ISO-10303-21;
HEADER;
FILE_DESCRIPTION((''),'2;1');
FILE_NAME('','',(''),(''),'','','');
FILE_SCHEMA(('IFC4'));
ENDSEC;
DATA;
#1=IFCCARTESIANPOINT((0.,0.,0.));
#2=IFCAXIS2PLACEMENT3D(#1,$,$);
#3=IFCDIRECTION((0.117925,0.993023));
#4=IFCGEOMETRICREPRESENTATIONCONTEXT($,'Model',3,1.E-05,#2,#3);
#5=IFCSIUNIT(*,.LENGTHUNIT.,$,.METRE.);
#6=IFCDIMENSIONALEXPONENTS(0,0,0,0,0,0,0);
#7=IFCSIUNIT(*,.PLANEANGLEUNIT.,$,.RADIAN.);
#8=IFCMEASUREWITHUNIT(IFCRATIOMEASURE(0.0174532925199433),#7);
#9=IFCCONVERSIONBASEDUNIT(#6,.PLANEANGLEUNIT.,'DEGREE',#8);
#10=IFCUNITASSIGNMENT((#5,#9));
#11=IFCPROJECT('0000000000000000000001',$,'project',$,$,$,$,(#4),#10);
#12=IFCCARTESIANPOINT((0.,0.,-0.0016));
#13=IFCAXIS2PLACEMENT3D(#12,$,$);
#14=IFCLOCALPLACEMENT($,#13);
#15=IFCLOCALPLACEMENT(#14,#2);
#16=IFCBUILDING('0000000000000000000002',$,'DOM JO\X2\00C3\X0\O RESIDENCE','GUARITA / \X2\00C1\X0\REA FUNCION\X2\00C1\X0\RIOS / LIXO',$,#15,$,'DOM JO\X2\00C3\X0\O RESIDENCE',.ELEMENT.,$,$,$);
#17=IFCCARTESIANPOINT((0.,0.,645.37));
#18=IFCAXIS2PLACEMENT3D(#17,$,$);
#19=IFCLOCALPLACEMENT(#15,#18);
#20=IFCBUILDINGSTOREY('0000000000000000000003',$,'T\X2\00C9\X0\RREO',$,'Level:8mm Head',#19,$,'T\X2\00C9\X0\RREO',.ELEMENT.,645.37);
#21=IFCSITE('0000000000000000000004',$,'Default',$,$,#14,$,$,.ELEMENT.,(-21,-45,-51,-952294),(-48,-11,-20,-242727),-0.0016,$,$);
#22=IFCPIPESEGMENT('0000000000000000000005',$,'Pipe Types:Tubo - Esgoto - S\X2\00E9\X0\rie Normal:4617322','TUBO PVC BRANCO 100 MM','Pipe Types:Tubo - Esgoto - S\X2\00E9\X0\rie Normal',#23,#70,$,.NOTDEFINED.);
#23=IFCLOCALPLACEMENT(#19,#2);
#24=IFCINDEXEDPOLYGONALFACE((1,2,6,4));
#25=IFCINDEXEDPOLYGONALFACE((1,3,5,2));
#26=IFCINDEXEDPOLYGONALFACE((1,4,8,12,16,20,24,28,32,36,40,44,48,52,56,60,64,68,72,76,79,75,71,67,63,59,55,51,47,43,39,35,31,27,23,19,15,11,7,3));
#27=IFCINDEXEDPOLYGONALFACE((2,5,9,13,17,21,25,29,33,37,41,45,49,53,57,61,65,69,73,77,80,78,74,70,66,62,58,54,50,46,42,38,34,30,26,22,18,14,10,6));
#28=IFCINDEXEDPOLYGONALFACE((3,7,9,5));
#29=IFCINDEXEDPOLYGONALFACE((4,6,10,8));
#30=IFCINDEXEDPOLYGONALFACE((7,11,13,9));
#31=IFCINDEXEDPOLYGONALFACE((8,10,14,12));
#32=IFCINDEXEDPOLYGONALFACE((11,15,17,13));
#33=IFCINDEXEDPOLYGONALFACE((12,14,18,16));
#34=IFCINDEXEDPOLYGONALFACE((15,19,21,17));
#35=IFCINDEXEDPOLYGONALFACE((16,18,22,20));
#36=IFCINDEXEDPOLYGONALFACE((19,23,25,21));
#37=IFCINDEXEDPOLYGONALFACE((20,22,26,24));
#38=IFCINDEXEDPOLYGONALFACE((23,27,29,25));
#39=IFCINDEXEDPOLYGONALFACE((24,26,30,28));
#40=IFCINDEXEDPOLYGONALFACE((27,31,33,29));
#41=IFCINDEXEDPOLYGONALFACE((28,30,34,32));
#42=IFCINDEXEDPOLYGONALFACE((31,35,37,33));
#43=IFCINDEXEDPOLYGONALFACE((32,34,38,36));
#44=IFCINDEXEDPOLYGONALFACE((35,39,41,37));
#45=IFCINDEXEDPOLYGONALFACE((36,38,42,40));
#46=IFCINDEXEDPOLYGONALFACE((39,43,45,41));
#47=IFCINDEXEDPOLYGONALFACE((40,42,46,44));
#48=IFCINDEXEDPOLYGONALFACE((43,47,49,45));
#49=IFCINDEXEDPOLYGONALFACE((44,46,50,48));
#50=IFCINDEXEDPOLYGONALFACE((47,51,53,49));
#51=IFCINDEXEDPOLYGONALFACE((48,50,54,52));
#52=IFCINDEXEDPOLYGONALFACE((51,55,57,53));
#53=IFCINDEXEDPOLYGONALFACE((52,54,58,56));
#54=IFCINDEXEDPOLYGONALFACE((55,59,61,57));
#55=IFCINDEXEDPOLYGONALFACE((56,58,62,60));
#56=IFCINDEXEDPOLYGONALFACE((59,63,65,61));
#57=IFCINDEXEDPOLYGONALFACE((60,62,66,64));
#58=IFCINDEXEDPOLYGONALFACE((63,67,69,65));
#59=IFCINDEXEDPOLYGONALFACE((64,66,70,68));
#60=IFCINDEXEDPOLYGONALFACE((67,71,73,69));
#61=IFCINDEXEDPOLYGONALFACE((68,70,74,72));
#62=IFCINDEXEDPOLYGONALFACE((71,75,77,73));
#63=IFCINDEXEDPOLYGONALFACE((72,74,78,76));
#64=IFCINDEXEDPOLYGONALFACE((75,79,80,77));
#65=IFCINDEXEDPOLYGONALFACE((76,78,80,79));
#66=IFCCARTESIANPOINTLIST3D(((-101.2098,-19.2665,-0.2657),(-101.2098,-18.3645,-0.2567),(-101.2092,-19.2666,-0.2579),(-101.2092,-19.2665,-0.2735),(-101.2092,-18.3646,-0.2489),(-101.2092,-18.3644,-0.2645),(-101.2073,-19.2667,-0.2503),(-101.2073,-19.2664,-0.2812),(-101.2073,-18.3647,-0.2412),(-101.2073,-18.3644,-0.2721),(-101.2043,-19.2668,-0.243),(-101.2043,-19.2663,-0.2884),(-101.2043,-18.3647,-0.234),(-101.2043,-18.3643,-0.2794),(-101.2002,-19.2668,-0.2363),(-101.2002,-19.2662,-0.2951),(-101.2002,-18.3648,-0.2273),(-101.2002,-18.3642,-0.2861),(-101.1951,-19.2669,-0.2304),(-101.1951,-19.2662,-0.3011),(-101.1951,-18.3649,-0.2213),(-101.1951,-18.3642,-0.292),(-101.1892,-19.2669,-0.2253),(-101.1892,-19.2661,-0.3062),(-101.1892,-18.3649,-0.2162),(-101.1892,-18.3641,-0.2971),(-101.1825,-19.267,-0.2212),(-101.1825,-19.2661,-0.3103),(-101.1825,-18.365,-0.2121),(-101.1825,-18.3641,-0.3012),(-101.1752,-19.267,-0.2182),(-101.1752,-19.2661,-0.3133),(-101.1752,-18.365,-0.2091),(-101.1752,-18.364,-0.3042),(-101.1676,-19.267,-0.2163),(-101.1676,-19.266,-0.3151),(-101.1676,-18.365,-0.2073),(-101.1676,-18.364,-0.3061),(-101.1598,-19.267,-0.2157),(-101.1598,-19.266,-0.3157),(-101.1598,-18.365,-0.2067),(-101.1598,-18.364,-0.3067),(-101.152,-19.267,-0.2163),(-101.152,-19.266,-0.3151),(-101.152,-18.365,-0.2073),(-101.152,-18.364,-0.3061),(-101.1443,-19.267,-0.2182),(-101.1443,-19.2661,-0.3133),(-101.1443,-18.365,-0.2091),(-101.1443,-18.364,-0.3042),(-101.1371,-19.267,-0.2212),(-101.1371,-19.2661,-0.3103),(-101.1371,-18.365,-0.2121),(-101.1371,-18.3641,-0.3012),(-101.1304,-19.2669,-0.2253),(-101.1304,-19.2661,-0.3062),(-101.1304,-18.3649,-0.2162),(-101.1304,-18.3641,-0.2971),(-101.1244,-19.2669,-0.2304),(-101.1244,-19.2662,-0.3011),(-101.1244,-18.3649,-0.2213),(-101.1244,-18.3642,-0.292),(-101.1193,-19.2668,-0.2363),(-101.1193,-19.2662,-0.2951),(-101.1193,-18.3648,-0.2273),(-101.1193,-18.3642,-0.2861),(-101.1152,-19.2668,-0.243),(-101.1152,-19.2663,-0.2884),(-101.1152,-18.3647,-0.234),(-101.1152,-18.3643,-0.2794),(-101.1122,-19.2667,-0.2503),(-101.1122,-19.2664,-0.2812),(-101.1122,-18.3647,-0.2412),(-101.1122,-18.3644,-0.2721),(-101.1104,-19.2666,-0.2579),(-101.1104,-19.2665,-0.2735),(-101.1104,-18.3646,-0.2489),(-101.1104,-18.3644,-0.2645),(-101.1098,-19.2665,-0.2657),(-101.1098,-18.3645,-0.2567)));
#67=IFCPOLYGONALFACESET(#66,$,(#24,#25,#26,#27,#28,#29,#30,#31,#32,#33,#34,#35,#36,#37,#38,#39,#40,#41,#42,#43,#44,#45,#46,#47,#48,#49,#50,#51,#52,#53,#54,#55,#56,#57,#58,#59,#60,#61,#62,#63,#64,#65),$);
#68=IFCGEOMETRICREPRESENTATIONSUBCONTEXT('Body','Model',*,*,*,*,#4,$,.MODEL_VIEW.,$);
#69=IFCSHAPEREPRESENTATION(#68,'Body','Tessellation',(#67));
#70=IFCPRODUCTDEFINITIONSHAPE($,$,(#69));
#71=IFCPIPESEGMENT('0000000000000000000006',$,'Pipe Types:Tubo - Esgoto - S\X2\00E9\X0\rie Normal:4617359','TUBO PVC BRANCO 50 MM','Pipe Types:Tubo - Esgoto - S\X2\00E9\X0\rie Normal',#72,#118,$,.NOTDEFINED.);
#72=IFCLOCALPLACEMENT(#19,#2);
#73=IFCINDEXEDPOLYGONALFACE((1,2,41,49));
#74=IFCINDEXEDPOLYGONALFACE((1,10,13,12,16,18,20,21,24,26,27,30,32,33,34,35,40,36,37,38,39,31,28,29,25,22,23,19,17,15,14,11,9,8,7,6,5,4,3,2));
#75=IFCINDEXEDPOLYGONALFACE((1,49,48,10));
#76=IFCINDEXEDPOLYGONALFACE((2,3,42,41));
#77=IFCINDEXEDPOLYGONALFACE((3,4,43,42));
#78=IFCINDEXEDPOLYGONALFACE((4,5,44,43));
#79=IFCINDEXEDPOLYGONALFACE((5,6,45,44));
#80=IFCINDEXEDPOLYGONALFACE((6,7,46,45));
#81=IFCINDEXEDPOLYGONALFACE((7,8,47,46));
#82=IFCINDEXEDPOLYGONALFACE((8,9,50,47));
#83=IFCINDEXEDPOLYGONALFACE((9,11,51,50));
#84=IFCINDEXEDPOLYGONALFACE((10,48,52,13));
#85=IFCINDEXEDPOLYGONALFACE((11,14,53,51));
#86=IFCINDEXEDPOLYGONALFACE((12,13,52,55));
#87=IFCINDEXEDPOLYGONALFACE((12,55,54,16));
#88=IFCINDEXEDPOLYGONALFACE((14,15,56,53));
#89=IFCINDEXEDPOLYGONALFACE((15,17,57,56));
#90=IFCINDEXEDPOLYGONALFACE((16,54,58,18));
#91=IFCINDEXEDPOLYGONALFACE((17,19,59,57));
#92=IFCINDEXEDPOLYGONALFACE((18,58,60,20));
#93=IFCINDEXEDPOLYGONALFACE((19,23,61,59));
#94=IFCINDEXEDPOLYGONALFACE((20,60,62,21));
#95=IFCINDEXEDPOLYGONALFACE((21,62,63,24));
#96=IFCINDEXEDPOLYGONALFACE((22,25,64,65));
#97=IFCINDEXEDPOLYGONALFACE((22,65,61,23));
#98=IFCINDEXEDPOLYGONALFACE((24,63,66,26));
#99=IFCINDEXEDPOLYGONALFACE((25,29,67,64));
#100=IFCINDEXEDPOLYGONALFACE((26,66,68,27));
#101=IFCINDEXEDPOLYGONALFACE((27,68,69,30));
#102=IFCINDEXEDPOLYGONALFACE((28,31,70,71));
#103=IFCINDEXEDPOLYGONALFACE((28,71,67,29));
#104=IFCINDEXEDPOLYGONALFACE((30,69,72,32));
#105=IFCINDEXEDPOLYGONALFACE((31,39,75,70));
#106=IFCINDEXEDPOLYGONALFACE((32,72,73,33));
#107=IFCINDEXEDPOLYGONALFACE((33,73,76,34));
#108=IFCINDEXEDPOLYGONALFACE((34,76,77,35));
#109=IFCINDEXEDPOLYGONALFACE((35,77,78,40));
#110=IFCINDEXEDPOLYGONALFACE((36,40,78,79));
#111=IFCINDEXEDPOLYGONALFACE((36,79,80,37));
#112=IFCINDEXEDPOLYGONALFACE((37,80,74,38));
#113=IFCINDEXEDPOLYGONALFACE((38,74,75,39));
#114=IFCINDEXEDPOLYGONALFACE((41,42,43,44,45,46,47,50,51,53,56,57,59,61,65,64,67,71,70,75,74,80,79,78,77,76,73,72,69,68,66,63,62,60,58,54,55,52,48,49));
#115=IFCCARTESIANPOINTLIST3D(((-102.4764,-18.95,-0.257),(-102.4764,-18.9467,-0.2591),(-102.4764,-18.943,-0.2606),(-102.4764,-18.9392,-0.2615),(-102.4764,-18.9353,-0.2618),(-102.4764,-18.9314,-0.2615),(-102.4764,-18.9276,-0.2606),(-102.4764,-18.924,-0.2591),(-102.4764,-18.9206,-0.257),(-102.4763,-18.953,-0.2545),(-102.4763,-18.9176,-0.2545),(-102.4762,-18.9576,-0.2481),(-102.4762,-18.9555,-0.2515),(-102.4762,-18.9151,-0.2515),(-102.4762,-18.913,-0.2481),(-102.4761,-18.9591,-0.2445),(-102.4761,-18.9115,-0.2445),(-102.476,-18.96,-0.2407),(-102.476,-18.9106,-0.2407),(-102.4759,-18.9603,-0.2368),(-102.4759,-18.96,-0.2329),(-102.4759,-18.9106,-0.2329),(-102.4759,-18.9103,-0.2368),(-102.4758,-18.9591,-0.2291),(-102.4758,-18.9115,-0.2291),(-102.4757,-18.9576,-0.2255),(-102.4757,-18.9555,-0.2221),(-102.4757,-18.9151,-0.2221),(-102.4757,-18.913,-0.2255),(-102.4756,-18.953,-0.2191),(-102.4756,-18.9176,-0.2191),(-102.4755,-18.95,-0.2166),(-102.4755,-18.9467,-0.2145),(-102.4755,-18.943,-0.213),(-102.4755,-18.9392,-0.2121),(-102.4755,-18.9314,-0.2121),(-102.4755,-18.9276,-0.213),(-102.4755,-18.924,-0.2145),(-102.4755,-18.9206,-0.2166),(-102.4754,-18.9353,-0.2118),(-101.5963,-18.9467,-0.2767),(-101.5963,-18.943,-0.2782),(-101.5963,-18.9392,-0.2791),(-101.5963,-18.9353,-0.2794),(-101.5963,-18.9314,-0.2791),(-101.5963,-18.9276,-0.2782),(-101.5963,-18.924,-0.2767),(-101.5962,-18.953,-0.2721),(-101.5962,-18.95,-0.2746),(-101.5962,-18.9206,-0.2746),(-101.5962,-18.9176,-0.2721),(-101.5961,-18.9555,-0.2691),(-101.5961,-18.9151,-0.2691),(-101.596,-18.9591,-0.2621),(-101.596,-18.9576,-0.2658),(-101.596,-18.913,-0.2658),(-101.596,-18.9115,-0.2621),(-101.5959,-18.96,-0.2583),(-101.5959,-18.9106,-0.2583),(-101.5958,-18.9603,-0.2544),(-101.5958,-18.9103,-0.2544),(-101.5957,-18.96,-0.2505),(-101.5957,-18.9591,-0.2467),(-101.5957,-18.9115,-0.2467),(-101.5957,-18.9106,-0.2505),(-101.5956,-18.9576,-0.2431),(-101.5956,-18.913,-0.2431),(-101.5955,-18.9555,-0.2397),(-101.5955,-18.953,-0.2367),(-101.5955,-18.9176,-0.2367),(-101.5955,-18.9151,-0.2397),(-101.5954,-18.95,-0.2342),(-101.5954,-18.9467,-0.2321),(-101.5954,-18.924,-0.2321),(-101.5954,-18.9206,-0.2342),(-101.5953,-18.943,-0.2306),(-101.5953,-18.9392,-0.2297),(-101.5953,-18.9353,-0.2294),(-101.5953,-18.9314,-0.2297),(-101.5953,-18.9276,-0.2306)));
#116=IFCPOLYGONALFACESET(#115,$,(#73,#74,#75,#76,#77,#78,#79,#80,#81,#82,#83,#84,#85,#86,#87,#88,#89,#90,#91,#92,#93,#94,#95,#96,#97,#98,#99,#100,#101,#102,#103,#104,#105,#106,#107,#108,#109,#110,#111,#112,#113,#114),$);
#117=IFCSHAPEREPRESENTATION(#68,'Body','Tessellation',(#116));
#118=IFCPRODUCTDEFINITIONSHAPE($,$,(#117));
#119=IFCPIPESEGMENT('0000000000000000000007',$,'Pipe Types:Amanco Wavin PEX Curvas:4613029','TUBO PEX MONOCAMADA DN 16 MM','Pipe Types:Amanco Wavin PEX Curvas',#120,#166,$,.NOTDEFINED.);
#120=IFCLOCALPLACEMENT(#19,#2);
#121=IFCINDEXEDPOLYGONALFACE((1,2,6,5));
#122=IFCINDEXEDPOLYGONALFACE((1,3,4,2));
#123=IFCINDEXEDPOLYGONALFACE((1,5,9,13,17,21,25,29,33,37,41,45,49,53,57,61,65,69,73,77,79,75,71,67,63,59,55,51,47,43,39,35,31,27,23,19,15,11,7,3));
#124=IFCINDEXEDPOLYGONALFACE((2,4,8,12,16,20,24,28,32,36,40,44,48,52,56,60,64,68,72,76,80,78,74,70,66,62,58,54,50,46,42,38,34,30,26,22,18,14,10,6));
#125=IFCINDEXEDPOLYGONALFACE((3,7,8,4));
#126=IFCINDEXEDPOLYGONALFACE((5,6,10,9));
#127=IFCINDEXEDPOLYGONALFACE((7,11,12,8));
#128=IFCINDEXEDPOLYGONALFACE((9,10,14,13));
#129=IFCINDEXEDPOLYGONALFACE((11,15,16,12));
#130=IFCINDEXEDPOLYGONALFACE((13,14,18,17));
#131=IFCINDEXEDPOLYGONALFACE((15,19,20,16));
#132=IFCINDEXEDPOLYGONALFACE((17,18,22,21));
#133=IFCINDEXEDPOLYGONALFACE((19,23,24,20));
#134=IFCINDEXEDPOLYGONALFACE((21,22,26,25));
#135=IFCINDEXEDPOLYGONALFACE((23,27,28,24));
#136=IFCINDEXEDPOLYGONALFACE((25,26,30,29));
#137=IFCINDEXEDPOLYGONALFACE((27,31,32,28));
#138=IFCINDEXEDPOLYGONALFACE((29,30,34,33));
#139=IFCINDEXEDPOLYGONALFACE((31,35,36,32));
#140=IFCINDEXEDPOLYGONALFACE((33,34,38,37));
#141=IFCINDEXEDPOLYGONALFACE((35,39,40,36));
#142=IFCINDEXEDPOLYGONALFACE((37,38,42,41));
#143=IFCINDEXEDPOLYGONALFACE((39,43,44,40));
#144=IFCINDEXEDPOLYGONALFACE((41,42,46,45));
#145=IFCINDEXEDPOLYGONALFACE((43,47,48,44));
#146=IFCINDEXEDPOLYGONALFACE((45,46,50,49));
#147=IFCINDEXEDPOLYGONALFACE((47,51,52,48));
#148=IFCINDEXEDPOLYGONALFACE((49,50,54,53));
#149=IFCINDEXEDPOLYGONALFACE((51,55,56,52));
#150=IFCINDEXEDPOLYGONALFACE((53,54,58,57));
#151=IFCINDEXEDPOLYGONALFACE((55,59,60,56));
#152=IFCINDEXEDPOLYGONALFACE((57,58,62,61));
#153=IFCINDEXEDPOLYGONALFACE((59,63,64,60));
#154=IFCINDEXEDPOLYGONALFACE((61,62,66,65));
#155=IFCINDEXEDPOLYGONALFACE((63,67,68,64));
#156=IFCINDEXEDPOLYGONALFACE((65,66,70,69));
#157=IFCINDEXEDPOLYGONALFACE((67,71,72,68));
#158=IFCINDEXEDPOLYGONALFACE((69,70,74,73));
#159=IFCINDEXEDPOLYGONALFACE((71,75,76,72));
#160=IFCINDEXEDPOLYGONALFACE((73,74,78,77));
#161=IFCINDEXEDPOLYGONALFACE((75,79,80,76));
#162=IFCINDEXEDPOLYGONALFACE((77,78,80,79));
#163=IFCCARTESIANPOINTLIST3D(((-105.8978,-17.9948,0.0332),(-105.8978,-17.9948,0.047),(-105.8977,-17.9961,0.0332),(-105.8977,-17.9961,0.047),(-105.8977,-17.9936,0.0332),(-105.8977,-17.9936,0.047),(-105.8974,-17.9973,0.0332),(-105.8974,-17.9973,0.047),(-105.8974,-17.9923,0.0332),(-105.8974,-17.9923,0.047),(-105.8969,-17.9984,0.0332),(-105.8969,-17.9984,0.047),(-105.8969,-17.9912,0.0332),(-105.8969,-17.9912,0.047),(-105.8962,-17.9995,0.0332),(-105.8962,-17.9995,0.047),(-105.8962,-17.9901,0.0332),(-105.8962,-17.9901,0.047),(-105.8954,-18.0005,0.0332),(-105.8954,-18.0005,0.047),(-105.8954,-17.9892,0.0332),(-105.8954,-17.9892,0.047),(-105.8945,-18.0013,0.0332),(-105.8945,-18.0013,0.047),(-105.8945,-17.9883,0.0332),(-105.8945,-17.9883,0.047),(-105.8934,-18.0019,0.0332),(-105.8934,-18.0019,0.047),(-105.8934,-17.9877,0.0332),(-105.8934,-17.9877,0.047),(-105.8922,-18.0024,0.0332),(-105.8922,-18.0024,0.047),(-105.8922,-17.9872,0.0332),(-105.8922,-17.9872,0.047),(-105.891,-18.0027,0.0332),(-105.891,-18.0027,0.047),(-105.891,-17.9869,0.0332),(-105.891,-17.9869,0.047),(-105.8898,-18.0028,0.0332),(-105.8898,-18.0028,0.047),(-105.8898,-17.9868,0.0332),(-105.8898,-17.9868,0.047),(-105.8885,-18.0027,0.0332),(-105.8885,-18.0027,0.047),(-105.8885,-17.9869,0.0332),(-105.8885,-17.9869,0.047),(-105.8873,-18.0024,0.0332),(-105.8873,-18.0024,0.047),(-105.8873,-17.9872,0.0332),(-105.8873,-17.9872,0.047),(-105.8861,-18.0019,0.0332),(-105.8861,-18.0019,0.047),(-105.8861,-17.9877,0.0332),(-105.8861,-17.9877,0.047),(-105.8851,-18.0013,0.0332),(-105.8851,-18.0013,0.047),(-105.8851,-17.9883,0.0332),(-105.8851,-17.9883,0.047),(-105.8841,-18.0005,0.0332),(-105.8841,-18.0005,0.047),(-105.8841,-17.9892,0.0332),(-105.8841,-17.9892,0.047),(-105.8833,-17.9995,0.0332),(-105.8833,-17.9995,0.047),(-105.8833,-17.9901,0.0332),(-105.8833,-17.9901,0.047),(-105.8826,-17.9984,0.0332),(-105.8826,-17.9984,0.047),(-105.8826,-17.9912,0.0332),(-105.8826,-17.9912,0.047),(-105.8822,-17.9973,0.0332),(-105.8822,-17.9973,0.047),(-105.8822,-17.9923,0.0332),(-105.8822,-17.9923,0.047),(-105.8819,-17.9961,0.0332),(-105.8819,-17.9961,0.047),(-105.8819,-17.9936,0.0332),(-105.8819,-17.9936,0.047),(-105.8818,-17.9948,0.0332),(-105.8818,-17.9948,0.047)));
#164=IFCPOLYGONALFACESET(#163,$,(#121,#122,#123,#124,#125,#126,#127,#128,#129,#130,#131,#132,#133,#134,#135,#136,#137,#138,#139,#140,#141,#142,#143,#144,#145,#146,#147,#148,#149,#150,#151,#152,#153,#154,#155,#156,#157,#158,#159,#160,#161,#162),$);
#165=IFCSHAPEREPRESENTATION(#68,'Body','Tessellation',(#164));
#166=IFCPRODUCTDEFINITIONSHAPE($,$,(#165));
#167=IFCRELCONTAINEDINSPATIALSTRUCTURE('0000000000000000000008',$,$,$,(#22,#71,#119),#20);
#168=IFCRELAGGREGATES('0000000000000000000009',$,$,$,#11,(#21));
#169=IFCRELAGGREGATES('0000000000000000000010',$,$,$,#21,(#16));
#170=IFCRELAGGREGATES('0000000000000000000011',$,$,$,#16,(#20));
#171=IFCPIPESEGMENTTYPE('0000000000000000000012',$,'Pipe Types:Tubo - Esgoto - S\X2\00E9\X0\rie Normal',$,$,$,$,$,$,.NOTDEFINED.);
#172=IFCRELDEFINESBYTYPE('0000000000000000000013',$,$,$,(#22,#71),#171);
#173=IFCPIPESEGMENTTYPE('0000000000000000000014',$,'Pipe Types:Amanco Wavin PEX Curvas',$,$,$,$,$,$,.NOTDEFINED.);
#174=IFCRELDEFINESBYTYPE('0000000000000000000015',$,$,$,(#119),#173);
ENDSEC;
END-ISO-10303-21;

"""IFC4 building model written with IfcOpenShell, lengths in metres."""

from ifc_helpers import new_model, entity, si_unit, converted_unit, direction, frame, origin, place, context, subcontext, project, spatial, indexed_curve, outline, extrude, type_object, element, save


model = new_model("IFC4")

# Units and contexts
model_context = context("Model", 3, precision=1e-05, world=origin(), true_north=direction((0.117925, 0.993023)))
body_context = subcontext(model_context, "Body", "Model", "MODEL_VIEW")
ifc_project = project(units=[si_unit("LENGTHUNIT", "METRE"), converted_unit("PLANEANGLEUNIT", "DEGREE", entity("IfcRatioMeasure", 0.0174532925199433), si_unit("PLANEANGLEUNIT", "RADIAN"), dimensions=[0, 0, 0, 0, 0, 0, 0])], contexts=[model_context])

# Site, building, storey
site_placement = place(None, frame((0.0, 0.0, -0.0016)))
site = spatial("IfcSite", under=ifc_project, at=site_placement, Name="Default", CompositionType="ELEMENT", RefLatitude=(-21, -45, -51, -952294), RefLongitude=(-48, -11, -20, -242727), RefElevation=-0.0016)
building_placement = place(site_placement, origin())
building = spatial("IfcBuilding", under=site, at=building_placement, Name="DOM JOÃO RESIDENCE", Description="GUARITA / ÁREA FUNCIONÁRIOS / LIXO", LongName="DOM JOÃO RESIDENCE", CompositionType="ELEMENT")
storey_placement = place(building_placement, frame((0.0, 0.0, 645.37)))
storey = spatial("IfcBuildingStorey", under=building, at=storey_placement, Name="TÉRREO", ObjectType="Level:8mm Head", LongName="TÉRREO", CompositionType="ELEMENT", Elevation=645.37)

# Pipe segments
pipe_segment_type_1 = type_object("IfcPipeSegmentType", Name="Pipe Types:Tubo - Esgoto - Série Normal", PredefinedType="NOTDEFINED")
pipe_segment_1_placement = place(storey_placement, frame((-101.2114, -19.2686, -0.3173)))
element("IfcPipeSegment", 1, at=pipe_segment_1_placement, inside=storey, type_object=pipe_segment_type_1, Name="Pipe Types:Tubo - Esgoto - Série Normal:4617322", Description="TUBO PVC BRANCO 100 MM", ObjectType="Pipe Types:Tubo - Esgoto - Série Normal", PredefinedType="NOTDEFINED", context=body_context, shape_type="SweptSolid", body=[
    extrude(outline(indexed_curve([(0.05, 0.0), (0.0494, 0.0078), (0.0476, 0.0155), (0.0446, 0.0227), (0.0405, 0.0294), (0.0354, 0.0354), (0.0294, 0.0405), (0.0227, 0.0446), (0.0155, 0.0476), (0.0078, 0.0494), (0.0, 0.05), (-0.0078, 0.0494), (-0.0155, 0.0476), (-0.0227, 0.0446), (-0.0294, 0.0405), (-0.0354, 0.0354), (-0.0405, 0.0294), (-0.0446, 0.0227), (-0.0476, 0.0155), (-0.0494, 0.0078), (-0.05, 0.0), (-0.0494, -0.0078), (-0.0476, -0.0155), (-0.0446, -0.0227), (-0.0405, -0.0294), (-0.0354, -0.0354), (-0.0294, -0.0405), (-0.0227, -0.0446), (-0.0155, -0.0476), (-0.0078, -0.0494), (0.0, -0.05), (0.0078, -0.0494), (0.0155, -0.0476), (0.0227, -0.0446), (0.0294, -0.0405), (0.0354, -0.0354), (0.0405, -0.0294), (0.0446, -0.0227), (0.0476, -0.0155), (0.0494, -0.0078), (0.05, 0.0)], self_intersect=False)), frame((0.0516, 0.0021, 0.0516), z_axis=(0.0, 0.99995, 0.01), x_axis=(-1.0, 0.0, 0.0)), (0.0, 0.0, 1.0), 0.9021),
])
pipe_segment_2_placement = place(storey_placement, frame((-102.478, -18.9619, -0.281)))
element("IfcPipeSegment", 2, at=pipe_segment_2_placement, inside=storey, type_object=pipe_segment_type_1, Name="Pipe Types:Tubo - Esgoto - Série Normal:4617359", Description="TUBO PVC BRANCO 50 MM", ObjectType="Pipe Types:Tubo - Esgoto - Série Normal", PredefinedType="NOTDEFINED", context=body_context, shape_type="SweptSolid", body=[
    extrude(outline(indexed_curve([(0.025, 0.0), (0.0247, 0.0039), (0.0238, 0.0077), (0.0223, 0.0113), (0.0202, 0.0147), (0.0177, 0.0177), (0.0147, 0.0202), (0.0113, 0.0223), (0.0077, 0.0238), (0.0039, 0.0247), (0.0, 0.025), (-0.0039, 0.0247), (-0.0077, 0.0238), (-0.0113, 0.0223), (-0.0147, 0.0202), (-0.0177, 0.0177), (-0.0202, 0.0147), (-0.0223, 0.0113), (-0.0238, 0.0077), (-0.0247, 0.0039), (-0.025, 0.0), (-0.0247, -0.0039), (-0.0238, -0.0077), (-0.0223, -0.0113), (-0.0202, -0.0147), (-0.0177, -0.0177), (-0.0147, -0.0202), (-0.0113, -0.0223), (-0.0077, -0.0238), (-0.0039, -0.0247), (0.0, -0.025), (0.0039, -0.0247), (0.0077, -0.0238), (0.0113, -0.0223), (0.0147, -0.0202), (0.0177, -0.0177), (0.0202, -0.0147), (0.0223, -0.0113), (0.0238, -0.0077), (0.0247, -0.0039), (0.025, 0.0)], self_intersect=False)), frame((0.8822, 0.0266, 0.0266), z_axis=(-0.9998, 0.0, 0.019997), x_axis=(0.0, 1.0, 0.0)), (0.0, 0.0, 1.0), 0.8803),
])
pipe_segment_type_2 = type_object("IfcPipeSegmentType", Name="Pipe Types:Amanco Wavin PEX Curvas", PredefinedType="NOTDEFINED")
pipe_segment_3_placement = place(storey_placement, frame((-105.8994, -18.0044, 0.0332)))
element("IfcPipeSegment", 3, at=pipe_segment_3_placement, inside=storey, type_object=pipe_segment_type_2, Name="Pipe Types:Amanco Wavin PEX Curvas:4613029", Description="TUBO PEX MONOCAMADA DN 16 MM", ObjectType="Pipe Types:Amanco Wavin PEX Curvas", PredefinedType="NOTDEFINED", context=body_context, shape_type="SweptSolid", body=[
    extrude(outline(indexed_curve([(0.008, 0.0), (0.0079, 0.0013), (0.0076, 0.0025), (0.0071, 0.0036), (0.0065, 0.0047), (0.0057, 0.0057), (0.0047, 0.0065), (0.0036, 0.0071), (0.0025, 0.0076), (0.0013, 0.0079), (0.0, 0.008), (-0.0013, 0.0079), (-0.0025, 0.0076), (-0.0036, 0.0071), (-0.0047, 0.0065), (-0.0057, 0.0057), (-0.0065, 0.0047), (-0.0071, 0.0036), (-0.0076, 0.0025), (-0.0079, 0.0013), (-0.008, 0.0), (-0.0079, -0.0013), (-0.0076, -0.0025), (-0.0071, -0.0036), (-0.0065, -0.0047), (-0.0057, -0.0057), (-0.0047, -0.0065), (-0.0036, -0.0071), (-0.0025, -0.0076), (-0.0013, -0.0079), (0.0, -0.008), (0.0013, -0.0079), (0.0025, -0.0076), (0.0036, -0.0071), (0.0047, -0.0065), (0.0057, -0.0057), (0.0065, -0.0047), (0.0071, -0.0036), (0.0076, -0.0025), (0.0079, -0.0013), (0.008, 0.0)], self_intersect=False)), frame((0.0096, 0.0096, 0.0)), (0.0, 0.0, 1.0), 0.0138),
])

save(model, "model.ifc")
